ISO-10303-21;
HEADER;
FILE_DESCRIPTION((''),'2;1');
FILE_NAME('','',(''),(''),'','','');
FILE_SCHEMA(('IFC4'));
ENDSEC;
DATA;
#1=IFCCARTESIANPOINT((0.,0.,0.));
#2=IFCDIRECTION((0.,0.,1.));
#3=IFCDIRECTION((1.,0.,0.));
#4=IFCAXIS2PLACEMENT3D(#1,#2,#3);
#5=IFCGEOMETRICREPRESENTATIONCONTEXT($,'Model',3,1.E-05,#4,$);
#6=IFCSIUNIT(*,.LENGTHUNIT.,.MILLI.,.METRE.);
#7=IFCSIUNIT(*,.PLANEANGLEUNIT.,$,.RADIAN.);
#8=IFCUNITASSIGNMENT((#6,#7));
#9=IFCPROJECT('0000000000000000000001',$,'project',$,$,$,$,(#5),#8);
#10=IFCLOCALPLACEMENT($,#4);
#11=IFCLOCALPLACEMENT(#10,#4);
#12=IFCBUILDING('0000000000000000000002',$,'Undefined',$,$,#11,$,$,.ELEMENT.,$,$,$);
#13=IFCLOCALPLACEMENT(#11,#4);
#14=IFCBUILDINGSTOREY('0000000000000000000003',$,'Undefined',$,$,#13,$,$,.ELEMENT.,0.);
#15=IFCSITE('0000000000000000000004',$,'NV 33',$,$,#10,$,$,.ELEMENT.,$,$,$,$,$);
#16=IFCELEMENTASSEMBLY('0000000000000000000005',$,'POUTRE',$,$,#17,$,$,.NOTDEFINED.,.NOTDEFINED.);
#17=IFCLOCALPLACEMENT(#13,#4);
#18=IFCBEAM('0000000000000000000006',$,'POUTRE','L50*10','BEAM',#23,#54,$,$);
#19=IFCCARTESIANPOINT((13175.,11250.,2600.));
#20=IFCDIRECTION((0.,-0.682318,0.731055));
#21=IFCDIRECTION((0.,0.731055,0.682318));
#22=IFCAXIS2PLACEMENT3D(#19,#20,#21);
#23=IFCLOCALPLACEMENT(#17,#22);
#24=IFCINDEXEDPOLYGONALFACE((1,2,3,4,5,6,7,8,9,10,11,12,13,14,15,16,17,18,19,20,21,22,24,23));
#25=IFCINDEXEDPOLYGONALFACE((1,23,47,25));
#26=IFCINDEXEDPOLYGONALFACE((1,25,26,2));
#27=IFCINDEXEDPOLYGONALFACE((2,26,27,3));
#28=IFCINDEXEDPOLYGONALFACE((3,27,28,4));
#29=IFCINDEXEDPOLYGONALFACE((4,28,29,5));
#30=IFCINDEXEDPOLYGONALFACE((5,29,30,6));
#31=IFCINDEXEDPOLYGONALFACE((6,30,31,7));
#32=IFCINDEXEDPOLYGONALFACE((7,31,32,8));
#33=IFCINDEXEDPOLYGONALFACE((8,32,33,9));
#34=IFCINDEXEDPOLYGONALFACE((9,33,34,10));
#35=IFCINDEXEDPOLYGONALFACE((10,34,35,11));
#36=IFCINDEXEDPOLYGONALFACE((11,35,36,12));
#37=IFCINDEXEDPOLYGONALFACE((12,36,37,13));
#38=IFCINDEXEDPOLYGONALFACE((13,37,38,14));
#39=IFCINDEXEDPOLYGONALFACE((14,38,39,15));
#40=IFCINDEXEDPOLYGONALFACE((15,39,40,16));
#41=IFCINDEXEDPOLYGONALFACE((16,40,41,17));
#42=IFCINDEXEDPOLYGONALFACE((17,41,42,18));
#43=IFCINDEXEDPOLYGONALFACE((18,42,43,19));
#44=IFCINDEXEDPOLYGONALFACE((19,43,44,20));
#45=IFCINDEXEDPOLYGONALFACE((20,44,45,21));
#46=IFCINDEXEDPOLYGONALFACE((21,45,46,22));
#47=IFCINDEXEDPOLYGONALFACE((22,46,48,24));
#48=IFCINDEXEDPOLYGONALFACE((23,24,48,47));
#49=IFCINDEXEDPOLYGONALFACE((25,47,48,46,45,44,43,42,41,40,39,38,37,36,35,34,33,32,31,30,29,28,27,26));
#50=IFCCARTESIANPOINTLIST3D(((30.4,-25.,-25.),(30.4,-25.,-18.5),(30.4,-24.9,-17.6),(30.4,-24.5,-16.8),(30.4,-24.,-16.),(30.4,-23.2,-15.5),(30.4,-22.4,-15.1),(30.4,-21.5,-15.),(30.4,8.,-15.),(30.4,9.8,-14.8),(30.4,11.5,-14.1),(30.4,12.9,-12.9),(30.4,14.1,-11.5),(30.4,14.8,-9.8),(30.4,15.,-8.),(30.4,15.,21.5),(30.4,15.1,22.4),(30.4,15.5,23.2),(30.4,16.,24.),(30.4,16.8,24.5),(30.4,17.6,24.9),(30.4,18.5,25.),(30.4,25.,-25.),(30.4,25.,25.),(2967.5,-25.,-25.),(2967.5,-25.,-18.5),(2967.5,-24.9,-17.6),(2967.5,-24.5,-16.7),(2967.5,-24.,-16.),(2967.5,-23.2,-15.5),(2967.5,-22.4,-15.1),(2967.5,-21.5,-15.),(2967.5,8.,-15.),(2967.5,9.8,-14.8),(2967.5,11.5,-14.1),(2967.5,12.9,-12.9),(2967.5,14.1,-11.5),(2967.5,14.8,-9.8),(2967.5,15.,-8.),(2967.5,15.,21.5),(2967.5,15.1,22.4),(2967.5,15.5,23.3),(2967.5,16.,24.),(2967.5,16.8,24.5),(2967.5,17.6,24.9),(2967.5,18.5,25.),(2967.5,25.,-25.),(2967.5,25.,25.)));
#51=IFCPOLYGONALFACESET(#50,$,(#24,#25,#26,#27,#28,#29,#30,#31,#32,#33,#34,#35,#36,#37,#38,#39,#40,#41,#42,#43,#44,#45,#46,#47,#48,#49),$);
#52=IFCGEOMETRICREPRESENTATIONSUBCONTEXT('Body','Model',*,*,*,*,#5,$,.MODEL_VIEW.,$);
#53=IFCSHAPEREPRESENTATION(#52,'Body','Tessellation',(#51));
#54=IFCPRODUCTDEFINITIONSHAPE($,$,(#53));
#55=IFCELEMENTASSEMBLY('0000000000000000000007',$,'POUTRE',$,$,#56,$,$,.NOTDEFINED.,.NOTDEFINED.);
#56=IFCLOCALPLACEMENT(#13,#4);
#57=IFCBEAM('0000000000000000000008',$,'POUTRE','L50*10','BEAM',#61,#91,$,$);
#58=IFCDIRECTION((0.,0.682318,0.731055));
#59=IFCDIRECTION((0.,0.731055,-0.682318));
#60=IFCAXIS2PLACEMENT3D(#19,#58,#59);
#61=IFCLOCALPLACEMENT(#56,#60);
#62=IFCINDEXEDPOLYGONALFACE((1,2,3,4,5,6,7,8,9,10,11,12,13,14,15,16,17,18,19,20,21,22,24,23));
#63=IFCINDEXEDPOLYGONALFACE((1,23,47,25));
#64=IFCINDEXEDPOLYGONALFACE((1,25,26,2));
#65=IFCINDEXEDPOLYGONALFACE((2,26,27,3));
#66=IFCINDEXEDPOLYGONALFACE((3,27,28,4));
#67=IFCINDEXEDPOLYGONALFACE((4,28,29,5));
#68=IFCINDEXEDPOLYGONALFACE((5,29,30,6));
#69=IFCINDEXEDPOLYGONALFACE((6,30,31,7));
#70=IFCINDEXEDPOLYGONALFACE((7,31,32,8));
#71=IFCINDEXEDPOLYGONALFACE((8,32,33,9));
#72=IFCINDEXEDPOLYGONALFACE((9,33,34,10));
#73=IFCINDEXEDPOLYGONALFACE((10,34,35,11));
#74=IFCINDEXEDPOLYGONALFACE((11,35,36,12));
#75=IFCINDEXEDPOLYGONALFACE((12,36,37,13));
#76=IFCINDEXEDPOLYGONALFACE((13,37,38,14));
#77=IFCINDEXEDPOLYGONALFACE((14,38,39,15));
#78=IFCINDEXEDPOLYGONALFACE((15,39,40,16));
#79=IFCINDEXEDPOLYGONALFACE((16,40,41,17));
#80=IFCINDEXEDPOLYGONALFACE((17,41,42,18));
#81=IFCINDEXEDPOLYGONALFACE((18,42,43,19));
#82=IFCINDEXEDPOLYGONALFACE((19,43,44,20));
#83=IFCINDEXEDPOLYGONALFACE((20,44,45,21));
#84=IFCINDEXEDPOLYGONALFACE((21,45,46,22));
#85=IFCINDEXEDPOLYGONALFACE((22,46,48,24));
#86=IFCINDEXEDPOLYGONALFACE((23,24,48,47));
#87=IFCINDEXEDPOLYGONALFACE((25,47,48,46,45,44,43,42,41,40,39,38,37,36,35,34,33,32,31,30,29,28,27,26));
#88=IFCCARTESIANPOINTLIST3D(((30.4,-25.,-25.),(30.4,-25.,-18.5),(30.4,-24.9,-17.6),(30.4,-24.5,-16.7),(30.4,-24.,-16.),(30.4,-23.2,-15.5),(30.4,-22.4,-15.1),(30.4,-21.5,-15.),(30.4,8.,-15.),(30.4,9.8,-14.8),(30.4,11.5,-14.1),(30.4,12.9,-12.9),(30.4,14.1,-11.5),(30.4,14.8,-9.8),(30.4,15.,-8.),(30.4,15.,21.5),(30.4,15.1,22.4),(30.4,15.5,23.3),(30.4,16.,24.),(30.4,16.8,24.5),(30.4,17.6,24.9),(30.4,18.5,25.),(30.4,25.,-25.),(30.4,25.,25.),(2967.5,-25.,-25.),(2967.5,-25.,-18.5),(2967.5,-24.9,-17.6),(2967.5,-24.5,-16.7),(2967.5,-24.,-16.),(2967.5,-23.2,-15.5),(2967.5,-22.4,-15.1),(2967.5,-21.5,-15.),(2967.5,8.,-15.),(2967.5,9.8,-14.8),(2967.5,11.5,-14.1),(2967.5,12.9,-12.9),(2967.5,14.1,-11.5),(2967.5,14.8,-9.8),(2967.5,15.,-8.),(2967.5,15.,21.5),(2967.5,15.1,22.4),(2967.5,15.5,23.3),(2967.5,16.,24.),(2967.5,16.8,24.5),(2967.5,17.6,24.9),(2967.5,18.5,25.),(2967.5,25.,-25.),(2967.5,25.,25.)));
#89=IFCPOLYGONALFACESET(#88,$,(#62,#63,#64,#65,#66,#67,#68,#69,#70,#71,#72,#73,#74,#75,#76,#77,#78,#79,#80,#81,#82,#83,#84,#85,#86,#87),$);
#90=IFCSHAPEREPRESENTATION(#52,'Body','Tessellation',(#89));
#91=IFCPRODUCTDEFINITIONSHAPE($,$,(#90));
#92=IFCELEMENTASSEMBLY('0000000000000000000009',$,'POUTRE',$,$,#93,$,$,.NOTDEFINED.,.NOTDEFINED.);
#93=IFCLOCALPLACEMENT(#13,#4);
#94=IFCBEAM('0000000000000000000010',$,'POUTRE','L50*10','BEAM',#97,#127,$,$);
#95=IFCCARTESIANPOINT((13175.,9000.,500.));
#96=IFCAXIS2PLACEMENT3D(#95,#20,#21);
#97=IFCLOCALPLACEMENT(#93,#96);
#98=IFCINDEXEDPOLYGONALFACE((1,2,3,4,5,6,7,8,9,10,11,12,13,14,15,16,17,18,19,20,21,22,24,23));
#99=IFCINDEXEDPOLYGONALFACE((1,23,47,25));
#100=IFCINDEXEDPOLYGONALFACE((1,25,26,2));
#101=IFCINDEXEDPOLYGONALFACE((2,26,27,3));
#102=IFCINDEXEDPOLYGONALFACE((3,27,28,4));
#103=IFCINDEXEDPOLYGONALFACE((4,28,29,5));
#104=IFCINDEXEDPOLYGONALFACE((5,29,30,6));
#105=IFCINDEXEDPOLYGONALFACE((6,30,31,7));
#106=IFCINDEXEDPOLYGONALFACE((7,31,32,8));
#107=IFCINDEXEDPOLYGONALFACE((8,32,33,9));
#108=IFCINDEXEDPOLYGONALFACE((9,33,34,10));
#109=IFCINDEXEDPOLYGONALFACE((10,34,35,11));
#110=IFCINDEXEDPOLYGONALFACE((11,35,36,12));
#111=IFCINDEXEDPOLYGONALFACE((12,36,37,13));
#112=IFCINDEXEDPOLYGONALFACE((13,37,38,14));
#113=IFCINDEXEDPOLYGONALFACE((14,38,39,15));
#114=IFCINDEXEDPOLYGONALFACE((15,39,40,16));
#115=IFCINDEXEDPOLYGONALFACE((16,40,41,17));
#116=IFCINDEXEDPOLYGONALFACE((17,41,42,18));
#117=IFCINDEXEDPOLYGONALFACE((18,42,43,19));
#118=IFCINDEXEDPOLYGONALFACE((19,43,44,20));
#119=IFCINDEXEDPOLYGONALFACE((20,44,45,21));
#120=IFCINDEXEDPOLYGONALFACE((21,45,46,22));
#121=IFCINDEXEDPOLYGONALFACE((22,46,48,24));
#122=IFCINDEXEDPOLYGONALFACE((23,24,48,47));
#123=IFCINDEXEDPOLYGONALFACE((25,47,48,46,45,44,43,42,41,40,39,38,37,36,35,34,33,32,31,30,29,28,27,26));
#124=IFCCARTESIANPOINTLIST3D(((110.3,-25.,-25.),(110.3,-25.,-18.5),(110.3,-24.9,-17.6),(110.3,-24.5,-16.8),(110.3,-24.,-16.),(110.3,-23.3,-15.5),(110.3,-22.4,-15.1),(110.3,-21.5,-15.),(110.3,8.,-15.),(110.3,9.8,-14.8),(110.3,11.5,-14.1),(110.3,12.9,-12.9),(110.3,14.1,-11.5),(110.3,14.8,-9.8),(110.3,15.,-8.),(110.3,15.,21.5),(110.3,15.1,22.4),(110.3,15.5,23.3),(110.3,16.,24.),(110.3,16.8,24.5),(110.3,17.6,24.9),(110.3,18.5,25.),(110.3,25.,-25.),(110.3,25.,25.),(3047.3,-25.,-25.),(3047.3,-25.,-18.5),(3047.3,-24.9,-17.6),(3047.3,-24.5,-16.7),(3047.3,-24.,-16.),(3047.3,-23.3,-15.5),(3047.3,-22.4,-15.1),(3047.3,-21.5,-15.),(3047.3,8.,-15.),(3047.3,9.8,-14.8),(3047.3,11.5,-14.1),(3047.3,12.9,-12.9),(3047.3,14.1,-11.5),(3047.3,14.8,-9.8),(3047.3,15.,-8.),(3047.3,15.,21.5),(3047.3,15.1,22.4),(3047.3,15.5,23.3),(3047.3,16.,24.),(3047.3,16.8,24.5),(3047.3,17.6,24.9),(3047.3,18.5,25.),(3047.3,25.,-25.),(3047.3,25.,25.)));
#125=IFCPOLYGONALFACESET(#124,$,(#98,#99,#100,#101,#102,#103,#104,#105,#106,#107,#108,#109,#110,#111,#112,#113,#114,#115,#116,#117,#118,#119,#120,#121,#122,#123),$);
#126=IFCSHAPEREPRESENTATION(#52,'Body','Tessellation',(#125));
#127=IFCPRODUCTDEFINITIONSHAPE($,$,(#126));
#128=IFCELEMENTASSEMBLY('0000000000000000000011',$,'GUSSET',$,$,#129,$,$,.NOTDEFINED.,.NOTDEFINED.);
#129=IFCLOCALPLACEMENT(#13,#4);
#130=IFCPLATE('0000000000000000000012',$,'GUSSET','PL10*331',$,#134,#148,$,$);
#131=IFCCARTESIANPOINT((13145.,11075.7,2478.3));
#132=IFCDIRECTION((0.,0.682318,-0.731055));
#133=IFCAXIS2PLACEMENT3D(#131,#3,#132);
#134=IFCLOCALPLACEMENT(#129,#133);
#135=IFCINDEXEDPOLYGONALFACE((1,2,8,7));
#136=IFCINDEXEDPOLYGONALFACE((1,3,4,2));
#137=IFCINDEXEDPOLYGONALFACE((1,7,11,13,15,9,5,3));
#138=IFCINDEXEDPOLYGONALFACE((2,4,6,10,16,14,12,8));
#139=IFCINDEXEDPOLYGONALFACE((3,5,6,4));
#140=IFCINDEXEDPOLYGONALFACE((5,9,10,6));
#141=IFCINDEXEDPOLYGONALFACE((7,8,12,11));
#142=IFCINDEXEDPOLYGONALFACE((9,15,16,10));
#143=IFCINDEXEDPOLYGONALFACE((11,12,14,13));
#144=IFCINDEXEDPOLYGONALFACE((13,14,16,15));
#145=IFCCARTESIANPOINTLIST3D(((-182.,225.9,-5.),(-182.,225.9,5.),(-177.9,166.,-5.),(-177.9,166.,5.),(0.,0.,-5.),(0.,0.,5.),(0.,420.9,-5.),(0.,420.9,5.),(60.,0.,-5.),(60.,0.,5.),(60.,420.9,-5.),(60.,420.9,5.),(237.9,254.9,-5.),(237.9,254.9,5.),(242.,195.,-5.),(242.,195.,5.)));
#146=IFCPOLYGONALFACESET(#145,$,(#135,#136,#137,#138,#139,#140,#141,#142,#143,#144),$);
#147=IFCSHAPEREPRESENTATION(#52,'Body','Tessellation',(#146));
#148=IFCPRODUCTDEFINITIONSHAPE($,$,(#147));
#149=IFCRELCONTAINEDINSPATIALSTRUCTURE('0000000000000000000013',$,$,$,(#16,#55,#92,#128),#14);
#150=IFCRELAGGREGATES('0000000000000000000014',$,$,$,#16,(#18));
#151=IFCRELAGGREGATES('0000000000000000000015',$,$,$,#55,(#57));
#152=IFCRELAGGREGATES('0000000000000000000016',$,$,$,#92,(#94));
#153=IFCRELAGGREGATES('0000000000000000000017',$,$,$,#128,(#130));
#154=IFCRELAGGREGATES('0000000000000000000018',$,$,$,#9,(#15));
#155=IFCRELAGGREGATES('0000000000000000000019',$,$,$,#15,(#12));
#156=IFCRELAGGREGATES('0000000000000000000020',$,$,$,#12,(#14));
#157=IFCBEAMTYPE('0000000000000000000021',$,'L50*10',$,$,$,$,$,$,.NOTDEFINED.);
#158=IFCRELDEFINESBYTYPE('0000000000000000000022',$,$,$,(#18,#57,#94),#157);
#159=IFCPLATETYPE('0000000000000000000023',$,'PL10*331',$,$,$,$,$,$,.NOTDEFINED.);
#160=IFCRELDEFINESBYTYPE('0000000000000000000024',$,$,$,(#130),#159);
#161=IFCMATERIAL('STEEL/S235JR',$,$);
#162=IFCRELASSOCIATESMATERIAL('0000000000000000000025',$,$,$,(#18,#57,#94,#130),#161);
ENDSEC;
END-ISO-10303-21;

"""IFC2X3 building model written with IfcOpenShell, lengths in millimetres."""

from ifc_helpers import new_model, si_unit, frame, origin_with_axes, origin_2d_with_axis, place, context, subcontext, project, spatial, polyline, l_section, outline, extrude, clip, halfspace, material, type_object, element, aggregate, save


model = new_model("IFC2X3")

# Units and contexts
model_context = context("Model", 3, precision=1e-05, world=origin_with_axes())
body_context = subcontext(model_context, "Body", "Model", "MODEL_VIEW")
ifc_project = project(units=[si_unit("LENGTHUNIT", "METRE", prefix="MILLI"), si_unit("PLANEANGLEUNIT", "RADIAN")], contexts=[model_context])

# Site, building, storey
site_placement = place(None, origin_with_axes())
site = spatial("IfcSite", under=ifc_project, at=site_placement, Name="NV 33", CompositionType="ELEMENT")
building_placement = place(site_placement, origin_with_axes())
building = spatial("IfcBuilding", under=site, at=building_placement, Name="Undefined", CompositionType="ELEMENT")
storey_placement = place(building_placement, origin_with_axes())
storey = spatial("IfcBuildingStorey", under=building, at=storey_placement, Name="Undefined", CompositionType="ELEMENT", Elevation=0.0)

# Element assemblies, beams
assembly_1_placement = place(storey_placement, origin_with_axes())
assembly_1 = element("IfcElementAssembly", 1, at=assembly_1_placement, inside=storey, Name="POUTRE", AssemblyPlace="NOTDEFINED", PredefinedType="NOTDEFINED")
ifc_material_1 = material(Name="STEEL/S235JR")
beam_type_1 = type_object("IfcBeamType", Name="L50*10", PredefinedType="NOTDEFINED")
beam_1_placement = place(assembly_1_placement, frame((13175.0, 11250.0, 2600.0), z_axis=(0.0, -0.682318, 0.731055), x_axis=(0.0, 0.731055, 0.682318)))
beam_1 = element("IfcBeam", 2, at=beam_1_placement, type_object=beam_type_1, material=ifc_material_1, Name="POUTRE", Description="L50*10", ObjectType="BEAM", context=body_context, shape_type="Clipping", body=[
    clip(clip(extrude(l_section(Depth=50.0, Width=50.0, Thickness=10.0, FilletRadius=7.0, EdgeRadius=3.5, at=origin_2d_with_axis()), frame((3077.7, 0.0, 0.0), z_axis=(-1.0, 0.0, 0.0), x_axis=(0.0, -1.0, 0.0)), (0.0, 0.0, 1.0), 3097.7), halfspace(frame((2967.5, 31.0, 0.0), z_axis=(-1.0, 0.0, 0.0), x_axis=(0.0, 0.0, 1.0)), True)), halfspace(frame((30.4, 0.0, 25.0), z_axis=(1.0, 0.0, 0.0), x_axis=(0.0, 1.0, 0.0)), True)),
])
assembly_2_placement = place(storey_placement, origin_with_axes())
assembly_2 = element("IfcElementAssembly", 3, at=assembly_2_placement, inside=storey, Name="POUTRE", AssemblyPlace="NOTDEFINED", PredefinedType="NOTDEFINED")
beam_2_placement = place(assembly_2_placement, frame((13175.0, 11250.0, 2600.0), z_axis=(0.0, 0.682318, 0.731055), x_axis=(0.0, 0.731055, -0.682318)))
beam_2 = element("IfcBeam", 4, at=beam_2_placement, type_object=beam_type_1, material=ifc_material_1, Name="POUTRE", Description="L50*10", ObjectType="BEAM", context=body_context, shape_type="Clipping", body=[
    clip(clip(extrude(l_section(Depth=50.0, Width=50.0, Thickness=10.0, FilletRadius=7.0, EdgeRadius=3.5, at=origin_2d_with_axis()), frame((3077.7, 0.0, 0.0), z_axis=(-1.0, 0.0, 0.0), x_axis=(0.0, -1.0, 0.0)), (0.0, 0.0, 1.0), 3097.7), halfspace(frame((2967.5, 31.0, 0.0), z_axis=(-1.0, 0.0, 0.0), x_axis=(0.0, 0.0, 1.0)), True)), halfspace(frame((30.4, 0.0, 25.0), z_axis=(1.0, 0.0, 0.0), x_axis=(0.0, 1.0, 0.0)), True)),
])
assembly_3_placement = place(storey_placement, origin_with_axes())
assembly_3 = element("IfcElementAssembly", 5, at=assembly_3_placement, inside=storey, Name="POUTRE", AssemblyPlace="NOTDEFINED", PredefinedType="NOTDEFINED")
beam_3_placement = place(assembly_3_placement, frame((13175.0, 9000.0, 500.0), z_axis=(0.0, -0.682318, 0.731055), x_axis=(0.0, 0.731055, 0.682318)))
beam_3 = element("IfcBeam", 6, at=beam_3_placement, type_object=beam_type_1, material=ifc_material_1, Name="POUTRE", Description="L50*10", ObjectType="BEAM", context=body_context, shape_type="Clipping", body=[
    clip(clip(extrude(l_section(Depth=50.0, Width=50.0, Thickness=10.0, FilletRadius=7.0, EdgeRadius=3.5, at=origin_2d_with_axis()), frame((3097.7, 0.0, 0.0), z_axis=(-1.0, 0.0, 0.0), x_axis=(0.0, -1.0, 0.0)), (0.0, 0.0, 1.0), 3097.7), halfspace(frame((3047.3, 0.0, -25.0), z_axis=(-1.0, 0.0, 0.0), x_axis=(0.0, 1.0, 0.0)), True)), halfspace(frame((110.3, 31.0, 0.0), z_axis=(1.0, 0.0, 0.0), x_axis=(0.0, 0.0, -1.0)), True)),
])

# Element assembly, plate
assembly_4_placement = place(storey_placement, origin_with_axes())
assembly_4 = element("IfcElementAssembly", 7, at=assembly_4_placement, inside=storey, Name="GUSSET", AssemblyPlace="NOTDEFINED", PredefinedType="NOTDEFINED")
plate_type_1 = type_object("IfcPlateType", Name="PL10*331", PredefinedType="NOTDEFINED")
plate_1_placement = place(assembly_4_placement, frame((13145.0, 11075.7, 2478.3), z_axis=(1.0, 0.0, 0.0), x_axis=(0.0, 0.682318, -0.731055)))
plate_1 = element("IfcPlate", 8, at=plate_1_placement, type_object=plate_type_1, material=ifc_material_1, Name="GUSSET", Description="PL10*331", context=body_context, shape_type="SweptSolid", body=[
    extrude(outline(polyline([(0.0, 0.0), (60.0, 0.0), (242.0, 195.0), (237.9, 254.9), (60.0, 420.9), (0.0, 420.9), (-182.0, 225.9), (-177.9, 166.0), (0.0, 0.0)])), frame((0.0, 0.0, -5.0), z_axis=(0.0, 0.0, 1.0), x_axis=(1.0, 0.0, 0.0)), (0.0, 0.0, 1.0), 10.0),
])

aggregate(assembly_1, [beam_1])
aggregate(assembly_2, [beam_2])
aggregate(assembly_3, [beam_3])

aggregate(assembly_4, [plate_1])

save(model, "model.ifc")
